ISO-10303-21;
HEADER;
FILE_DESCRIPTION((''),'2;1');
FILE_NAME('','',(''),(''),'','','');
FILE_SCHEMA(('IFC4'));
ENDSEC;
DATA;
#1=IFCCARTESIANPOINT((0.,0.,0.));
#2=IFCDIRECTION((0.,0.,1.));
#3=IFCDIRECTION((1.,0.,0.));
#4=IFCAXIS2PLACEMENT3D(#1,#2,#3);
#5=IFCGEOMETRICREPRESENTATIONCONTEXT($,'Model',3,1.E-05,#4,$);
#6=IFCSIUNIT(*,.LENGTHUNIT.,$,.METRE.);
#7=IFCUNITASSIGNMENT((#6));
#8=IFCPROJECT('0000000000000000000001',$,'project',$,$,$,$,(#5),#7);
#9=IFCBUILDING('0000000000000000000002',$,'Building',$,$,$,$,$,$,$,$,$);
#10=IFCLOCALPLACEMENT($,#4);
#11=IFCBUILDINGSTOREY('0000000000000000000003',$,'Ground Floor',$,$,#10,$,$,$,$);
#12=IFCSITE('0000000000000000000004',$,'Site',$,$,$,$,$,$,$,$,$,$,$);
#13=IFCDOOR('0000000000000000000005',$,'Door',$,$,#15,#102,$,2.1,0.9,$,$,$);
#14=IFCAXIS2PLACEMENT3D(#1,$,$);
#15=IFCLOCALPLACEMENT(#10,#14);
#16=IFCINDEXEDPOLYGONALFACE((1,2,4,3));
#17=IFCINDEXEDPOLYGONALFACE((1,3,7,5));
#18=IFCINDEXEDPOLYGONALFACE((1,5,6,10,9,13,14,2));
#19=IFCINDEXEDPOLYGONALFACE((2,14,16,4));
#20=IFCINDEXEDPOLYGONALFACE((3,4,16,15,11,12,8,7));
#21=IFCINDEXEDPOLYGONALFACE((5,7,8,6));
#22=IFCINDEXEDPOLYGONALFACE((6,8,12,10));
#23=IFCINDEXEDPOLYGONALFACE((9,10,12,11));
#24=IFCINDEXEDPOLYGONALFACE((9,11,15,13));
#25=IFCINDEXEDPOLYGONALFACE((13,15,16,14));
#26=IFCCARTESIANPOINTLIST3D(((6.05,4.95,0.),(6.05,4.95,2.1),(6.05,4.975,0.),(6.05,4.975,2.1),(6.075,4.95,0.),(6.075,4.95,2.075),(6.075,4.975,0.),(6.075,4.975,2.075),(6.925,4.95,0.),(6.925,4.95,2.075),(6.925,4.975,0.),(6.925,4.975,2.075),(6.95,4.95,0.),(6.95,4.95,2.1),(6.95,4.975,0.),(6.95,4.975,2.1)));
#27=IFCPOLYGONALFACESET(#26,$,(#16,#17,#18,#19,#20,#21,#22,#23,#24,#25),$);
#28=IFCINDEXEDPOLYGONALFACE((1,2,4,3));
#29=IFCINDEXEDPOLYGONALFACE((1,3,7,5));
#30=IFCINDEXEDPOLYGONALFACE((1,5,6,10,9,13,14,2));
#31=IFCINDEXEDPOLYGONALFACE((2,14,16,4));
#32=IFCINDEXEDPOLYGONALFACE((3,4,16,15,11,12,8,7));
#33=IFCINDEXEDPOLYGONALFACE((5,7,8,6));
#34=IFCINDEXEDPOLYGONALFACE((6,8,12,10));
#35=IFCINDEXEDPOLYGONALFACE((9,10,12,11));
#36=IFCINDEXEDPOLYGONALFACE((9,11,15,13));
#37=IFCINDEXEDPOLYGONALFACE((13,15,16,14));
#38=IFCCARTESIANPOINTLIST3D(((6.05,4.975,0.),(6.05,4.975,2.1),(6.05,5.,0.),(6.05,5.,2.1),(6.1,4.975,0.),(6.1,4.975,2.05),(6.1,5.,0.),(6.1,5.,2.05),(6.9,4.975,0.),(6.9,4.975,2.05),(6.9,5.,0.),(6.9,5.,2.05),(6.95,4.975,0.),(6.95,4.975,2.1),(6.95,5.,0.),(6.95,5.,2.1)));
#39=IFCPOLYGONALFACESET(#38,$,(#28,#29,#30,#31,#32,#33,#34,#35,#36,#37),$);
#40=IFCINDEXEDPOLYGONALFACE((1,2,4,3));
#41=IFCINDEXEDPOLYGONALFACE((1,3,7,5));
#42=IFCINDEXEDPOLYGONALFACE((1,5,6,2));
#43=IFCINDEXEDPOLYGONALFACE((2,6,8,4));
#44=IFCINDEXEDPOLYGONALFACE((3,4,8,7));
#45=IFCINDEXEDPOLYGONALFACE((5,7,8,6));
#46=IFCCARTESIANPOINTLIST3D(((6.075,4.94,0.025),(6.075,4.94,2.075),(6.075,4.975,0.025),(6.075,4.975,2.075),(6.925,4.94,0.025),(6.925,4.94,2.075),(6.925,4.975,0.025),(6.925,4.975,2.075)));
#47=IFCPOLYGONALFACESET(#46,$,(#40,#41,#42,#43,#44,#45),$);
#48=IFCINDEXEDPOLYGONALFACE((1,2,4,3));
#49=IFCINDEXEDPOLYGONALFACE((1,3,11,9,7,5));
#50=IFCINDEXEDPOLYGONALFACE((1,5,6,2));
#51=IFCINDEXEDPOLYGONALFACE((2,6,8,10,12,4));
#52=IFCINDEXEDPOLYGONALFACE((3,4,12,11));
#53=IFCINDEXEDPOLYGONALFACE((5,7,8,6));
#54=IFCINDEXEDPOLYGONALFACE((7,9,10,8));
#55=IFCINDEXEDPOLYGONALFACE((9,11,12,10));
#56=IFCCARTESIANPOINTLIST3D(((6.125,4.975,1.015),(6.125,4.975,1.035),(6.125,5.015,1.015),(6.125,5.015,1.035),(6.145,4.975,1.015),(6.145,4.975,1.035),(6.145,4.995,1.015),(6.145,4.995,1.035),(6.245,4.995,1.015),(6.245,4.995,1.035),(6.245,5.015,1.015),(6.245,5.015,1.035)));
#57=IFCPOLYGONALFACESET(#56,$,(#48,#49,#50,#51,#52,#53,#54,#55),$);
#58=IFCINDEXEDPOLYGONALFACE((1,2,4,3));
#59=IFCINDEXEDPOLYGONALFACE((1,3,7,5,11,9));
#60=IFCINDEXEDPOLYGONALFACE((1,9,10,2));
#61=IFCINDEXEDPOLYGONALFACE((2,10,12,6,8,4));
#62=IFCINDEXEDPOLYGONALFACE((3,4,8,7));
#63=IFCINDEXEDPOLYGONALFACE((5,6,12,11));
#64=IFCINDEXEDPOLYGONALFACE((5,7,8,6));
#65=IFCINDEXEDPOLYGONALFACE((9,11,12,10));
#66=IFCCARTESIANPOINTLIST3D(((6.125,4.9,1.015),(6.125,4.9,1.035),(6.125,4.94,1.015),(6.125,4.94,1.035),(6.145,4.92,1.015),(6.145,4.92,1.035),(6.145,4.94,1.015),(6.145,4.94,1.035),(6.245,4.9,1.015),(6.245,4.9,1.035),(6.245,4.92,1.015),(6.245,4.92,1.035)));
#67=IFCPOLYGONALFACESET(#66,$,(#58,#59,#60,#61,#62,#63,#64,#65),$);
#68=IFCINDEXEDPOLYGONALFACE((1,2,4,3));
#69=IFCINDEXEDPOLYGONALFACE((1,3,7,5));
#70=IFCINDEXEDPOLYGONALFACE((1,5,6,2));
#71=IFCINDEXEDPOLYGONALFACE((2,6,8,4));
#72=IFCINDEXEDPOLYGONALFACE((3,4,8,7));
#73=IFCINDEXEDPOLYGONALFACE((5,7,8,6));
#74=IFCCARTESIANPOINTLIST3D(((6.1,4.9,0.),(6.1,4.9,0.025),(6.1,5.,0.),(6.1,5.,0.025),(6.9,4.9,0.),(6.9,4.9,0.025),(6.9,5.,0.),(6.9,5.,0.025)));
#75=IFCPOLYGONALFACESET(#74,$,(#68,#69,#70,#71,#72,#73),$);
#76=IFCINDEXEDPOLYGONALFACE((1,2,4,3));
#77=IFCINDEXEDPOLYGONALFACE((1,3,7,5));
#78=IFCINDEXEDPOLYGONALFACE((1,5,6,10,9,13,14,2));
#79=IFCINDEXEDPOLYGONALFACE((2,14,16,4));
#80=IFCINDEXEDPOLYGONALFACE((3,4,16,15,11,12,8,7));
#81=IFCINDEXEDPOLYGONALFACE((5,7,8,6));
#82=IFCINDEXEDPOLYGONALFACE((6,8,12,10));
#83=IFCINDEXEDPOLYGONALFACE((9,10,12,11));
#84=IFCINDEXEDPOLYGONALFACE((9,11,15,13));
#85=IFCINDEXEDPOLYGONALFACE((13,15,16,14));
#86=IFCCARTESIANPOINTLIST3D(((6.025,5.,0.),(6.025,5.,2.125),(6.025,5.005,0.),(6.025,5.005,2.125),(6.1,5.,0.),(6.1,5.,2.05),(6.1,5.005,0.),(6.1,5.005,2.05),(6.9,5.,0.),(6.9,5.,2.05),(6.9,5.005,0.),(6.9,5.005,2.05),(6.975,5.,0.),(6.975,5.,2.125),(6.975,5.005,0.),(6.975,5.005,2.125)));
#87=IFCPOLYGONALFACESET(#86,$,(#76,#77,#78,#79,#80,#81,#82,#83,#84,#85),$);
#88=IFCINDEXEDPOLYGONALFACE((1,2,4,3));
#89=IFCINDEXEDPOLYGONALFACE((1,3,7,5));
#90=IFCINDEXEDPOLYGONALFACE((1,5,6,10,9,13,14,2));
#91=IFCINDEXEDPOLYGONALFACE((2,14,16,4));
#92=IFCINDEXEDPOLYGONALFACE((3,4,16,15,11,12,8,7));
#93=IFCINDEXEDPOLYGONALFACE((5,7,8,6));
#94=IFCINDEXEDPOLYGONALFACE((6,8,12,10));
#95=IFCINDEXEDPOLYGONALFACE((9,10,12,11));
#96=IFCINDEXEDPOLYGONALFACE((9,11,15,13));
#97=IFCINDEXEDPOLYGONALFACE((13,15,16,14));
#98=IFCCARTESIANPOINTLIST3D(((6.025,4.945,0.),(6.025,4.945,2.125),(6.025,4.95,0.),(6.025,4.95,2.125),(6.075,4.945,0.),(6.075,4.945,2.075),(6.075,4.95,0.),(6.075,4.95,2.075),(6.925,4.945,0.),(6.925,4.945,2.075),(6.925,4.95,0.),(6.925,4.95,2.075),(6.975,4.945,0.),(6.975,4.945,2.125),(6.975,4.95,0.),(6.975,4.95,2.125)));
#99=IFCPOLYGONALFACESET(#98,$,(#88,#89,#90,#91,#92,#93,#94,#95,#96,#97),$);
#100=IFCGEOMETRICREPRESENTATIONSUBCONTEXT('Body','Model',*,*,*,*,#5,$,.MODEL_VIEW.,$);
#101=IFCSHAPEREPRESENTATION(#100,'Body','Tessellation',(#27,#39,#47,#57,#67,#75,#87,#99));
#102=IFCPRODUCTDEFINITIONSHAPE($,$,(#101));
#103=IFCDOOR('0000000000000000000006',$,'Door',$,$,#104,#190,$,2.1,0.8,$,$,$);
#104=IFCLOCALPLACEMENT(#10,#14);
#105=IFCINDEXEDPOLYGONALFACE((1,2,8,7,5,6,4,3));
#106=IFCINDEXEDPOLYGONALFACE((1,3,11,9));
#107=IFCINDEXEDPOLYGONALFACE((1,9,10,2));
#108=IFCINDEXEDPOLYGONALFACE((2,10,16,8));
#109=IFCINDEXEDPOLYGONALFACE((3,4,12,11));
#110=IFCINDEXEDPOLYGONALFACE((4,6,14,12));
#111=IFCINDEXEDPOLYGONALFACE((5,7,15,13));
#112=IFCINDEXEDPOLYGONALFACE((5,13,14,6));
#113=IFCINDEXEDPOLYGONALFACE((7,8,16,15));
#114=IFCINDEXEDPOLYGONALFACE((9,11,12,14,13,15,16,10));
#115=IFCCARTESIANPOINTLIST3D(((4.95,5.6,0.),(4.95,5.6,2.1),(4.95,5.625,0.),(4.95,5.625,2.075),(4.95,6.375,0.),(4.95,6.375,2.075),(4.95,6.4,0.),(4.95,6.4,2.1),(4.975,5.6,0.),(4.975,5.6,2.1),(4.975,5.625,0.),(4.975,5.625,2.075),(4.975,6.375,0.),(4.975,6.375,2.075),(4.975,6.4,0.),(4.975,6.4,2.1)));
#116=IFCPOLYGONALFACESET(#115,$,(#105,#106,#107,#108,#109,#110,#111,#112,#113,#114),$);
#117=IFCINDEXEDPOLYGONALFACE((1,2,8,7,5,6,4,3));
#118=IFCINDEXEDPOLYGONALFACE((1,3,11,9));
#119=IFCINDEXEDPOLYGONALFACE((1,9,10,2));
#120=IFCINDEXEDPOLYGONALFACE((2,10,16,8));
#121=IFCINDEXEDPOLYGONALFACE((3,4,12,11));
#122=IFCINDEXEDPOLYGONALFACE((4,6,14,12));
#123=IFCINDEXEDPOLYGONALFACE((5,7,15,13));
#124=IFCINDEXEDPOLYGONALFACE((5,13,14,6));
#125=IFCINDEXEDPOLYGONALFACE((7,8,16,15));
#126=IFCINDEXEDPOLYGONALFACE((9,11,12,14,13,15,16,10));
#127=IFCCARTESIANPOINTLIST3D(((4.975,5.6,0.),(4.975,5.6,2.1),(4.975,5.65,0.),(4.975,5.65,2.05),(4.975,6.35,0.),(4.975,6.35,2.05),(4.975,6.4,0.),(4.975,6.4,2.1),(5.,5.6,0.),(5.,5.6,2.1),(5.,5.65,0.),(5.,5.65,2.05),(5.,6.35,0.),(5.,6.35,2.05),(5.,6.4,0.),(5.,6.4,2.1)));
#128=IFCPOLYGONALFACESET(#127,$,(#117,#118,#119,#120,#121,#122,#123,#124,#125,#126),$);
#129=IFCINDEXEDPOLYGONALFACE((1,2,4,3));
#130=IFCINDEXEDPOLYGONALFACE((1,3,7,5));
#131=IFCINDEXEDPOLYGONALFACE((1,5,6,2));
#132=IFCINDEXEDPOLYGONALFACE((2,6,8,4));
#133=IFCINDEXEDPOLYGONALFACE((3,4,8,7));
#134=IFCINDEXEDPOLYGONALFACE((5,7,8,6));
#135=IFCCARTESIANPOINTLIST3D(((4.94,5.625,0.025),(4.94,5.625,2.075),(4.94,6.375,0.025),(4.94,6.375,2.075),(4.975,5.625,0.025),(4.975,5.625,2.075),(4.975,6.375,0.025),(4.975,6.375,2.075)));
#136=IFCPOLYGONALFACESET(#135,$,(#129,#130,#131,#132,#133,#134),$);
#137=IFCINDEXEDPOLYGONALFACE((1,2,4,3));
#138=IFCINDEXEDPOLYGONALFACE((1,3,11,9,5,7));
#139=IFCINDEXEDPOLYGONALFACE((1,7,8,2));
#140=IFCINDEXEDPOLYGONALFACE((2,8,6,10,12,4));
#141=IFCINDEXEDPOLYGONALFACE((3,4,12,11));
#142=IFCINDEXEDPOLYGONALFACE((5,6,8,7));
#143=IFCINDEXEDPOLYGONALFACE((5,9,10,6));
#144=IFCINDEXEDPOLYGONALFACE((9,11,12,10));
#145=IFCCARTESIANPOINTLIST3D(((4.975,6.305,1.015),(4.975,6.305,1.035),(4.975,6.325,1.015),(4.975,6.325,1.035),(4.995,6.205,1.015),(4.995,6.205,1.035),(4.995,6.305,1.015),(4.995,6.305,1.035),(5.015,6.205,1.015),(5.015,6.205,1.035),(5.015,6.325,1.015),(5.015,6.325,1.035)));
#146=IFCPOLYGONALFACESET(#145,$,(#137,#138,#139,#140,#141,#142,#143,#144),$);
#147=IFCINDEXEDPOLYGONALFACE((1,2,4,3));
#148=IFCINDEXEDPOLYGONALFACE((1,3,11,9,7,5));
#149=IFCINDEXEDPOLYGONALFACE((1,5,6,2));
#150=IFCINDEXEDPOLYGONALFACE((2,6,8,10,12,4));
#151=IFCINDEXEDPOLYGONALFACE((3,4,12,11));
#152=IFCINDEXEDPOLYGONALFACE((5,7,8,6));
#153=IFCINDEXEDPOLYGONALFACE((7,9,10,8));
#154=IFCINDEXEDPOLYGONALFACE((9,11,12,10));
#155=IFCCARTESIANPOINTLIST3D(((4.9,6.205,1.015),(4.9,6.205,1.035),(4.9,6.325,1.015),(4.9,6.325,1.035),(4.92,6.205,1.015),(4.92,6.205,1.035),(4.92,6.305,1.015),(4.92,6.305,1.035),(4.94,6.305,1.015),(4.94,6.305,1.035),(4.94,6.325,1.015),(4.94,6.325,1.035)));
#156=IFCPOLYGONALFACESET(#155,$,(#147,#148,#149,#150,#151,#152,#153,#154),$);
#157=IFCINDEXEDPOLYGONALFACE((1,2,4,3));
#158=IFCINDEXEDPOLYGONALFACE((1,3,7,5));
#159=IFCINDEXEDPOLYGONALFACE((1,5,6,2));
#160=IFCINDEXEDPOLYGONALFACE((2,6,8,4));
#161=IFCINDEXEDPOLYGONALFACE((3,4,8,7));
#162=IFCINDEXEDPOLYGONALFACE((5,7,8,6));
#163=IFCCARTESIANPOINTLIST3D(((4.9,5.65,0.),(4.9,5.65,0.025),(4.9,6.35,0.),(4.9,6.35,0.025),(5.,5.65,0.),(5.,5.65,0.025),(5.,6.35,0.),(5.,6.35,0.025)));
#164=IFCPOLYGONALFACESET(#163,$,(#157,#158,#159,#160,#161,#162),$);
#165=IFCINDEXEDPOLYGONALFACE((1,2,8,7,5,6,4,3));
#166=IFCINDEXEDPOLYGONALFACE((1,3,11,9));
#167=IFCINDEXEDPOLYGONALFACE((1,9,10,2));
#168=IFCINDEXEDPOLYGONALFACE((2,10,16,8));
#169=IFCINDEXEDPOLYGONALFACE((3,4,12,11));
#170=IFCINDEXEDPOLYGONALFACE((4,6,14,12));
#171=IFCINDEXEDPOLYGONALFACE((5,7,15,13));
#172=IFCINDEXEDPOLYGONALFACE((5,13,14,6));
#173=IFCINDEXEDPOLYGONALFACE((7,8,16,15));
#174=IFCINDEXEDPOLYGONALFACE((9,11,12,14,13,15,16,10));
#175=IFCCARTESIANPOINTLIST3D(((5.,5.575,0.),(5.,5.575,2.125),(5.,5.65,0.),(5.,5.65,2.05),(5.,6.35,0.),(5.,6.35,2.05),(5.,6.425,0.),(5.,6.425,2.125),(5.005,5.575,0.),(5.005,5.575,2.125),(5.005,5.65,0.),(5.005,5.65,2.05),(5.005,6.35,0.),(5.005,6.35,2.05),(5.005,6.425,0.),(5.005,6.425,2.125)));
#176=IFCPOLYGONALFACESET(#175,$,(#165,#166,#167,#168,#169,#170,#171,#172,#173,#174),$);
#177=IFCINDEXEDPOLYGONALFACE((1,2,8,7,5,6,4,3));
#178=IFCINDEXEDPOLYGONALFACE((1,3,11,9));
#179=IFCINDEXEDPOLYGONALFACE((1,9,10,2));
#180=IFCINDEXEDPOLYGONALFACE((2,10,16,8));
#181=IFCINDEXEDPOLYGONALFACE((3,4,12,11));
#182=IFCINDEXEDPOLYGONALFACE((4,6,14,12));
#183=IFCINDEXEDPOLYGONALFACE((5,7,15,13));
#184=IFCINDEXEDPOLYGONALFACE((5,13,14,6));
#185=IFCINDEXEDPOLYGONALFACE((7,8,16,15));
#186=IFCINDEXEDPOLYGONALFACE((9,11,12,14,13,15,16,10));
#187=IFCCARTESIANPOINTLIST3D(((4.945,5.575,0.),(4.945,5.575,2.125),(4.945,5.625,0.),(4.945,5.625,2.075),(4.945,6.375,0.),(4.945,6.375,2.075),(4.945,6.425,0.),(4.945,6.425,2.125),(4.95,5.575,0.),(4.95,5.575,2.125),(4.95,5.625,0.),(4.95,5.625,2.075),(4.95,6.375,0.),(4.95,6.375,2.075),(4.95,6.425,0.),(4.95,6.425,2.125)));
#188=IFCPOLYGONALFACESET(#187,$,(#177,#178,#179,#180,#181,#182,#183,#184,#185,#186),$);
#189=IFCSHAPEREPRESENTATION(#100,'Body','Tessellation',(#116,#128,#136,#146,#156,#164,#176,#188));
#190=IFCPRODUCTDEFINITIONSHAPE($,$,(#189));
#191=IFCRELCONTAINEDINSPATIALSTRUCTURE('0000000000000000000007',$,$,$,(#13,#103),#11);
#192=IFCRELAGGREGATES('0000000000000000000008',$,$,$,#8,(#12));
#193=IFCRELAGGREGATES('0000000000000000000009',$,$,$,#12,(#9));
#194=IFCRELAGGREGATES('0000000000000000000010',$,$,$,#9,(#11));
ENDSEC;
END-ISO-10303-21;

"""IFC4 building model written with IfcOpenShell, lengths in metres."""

from ifc_helpers import new_model, si_unit, frame, origin_with_axes, place, context, subcontext, project, spatial, line, indexed_curve, outline, extrude, element, save


model = new_model("IFC4")

# Units and contexts
model_context = context("Model", 3, precision=1e-05, world=origin_with_axes())
body_context = subcontext(model_context, "Body", "Model", "MODEL_VIEW")
ifc_project = project(units=[si_unit("LENGTHUNIT", "METRE")], contexts=[model_context])

# Site, building, storey
site = spatial("IfcSite", under=ifc_project, Name="Site")
building = spatial("IfcBuilding", under=site, Name="Building")
storey_placement = place(None, origin_with_axes())
storey = spatial("IfcBuildingStorey", under=building, at=storey_placement, Name="Ground Floor")

# Doors
door_1_placement = place(storey_placement, frame((6.95, 5.0, 0.0), z_axis=(0.0, 0.0, 1.0), x_axis=(-1.0, 0.0, 0.0)))
element("IfcDoor", 1, at=door_1_placement, inside=storey, Name="Door", OverallHeight=2.1, OverallWidth=0.9, context=body_context, shape_type="SweptSolid", body=[
    extrude(outline(indexed_curve([(0.0, 0.0), (0.0, 2.1), (0.9, 2.1), (0.9, 0.0), (0.875, 0.0), (0.875, 2.075), (0.025, 2.075), (0.025, 0.0)], segments=[line(1, 2, 3, 4, 5, 6, 7, 8, 1)])), frame((0.0, 0.025, 0.0), z_axis=(0.0, -1.0, 0.0), x_axis=(1.0, 0.0, 0.0)), (0.0, 0.0, -1.0), 0.025),
    extrude(outline(indexed_curve([(0.0, 0.0), (0.0, 2.1), (0.9, 2.1), (0.9, 0.0), (0.85, 0.0), (0.85, 2.05), (0.05, 2.05), (0.05, 0.0)], segments=[line(1, 2, 3, 4, 5, 6, 7, 8, 1)])), frame((0.0, 0.0, 0.0), z_axis=(0.0, -1.0, 0.0), x_axis=(1.0, 0.0, 0.0)), (0.0, 0.0, -1.0), 0.025),
    extrude(outline(indexed_curve([(0.0, 0.0), (0.85, 0.0), (0.85, 0.035), (0.0, 0.035)], segments=[line(1, 2, 3, 4, 1)])), frame((0.025, 0.025, 0.025), z_axis=(0.0, 0.0, 1.0), x_axis=(1.0, 0.0, 0.0)), (0.0, 0.0, 1.0), 2.05),
    extrude(outline(indexed_curve([(0.0, 0.0), (0.0, -0.04), (-0.12, -0.04), (-0.12, -0.02), (-0.02, -0.02), (-0.02, 0.0)], segments=[line(1, 2, 3, 4, 5, 6, 1)])), frame((0.825, 0.025, 1.015), z_axis=(0.0, 0.0, 1.0), x_axis=(1.0, 0.0, 0.0)), (0.0, 0.0, 1.0), 0.02),
    extrude(outline(indexed_curve([(0.0, 0.0), (0.0, 0.04), (-0.12, 0.04), (-0.12, 0.02), (-0.02, 0.02), (-0.02, 0.0)], segments=[line(1, 2, 3, 4, 5, 6, 1)])), frame((0.825, 0.06, 1.015), z_axis=(0.0, 0.0, 1.0), x_axis=(1.0, 0.0, 0.0)), (0.0, 0.0, 1.0), 0.02),
    extrude(outline(indexed_curve([(0.0, 0.0), (0.8, 0.0), (0.8, 0.1), (0.0, 0.1)], segments=[line(1, 2, 3, 4, 1)])), frame((0.05, 0.0, 0.0), z_axis=(0.0, 0.0, 1.0), x_axis=(1.0, 0.0, 0.0)), (0.0, 0.0, 1.0), 0.025),
    extrude(outline(indexed_curve([(0.0, 0.0), (0.0, 2.125), (0.95, 2.125), (0.95, 0.0), (0.875, 0.0), (0.875, 2.05), (0.075, 2.05), (0.075, 0.0)], segments=[line(1, 2, 3, 4, 5, 6, 7, 8, 1)])), frame((-0.025, -0.005, 0.0), z_axis=(0.0, -1.0, 0.0), x_axis=(1.0, 0.0, 0.0)), (0.0, 0.0, -1.0), 0.005),
    extrude(outline(indexed_curve([(0.0, 0.0), (0.0, 2.125), (0.95, 2.125), (0.95, 0.0), (0.9, 0.0), (0.9, 2.075), (0.05, 2.075), (0.05, 0.0)], segments=[line(1, 2, 3, 4, 5, 6, 7, 8, 1)])), frame((-0.025, 0.05, 0.0), z_axis=(0.0, -1.0, 0.0), x_axis=(1.0, 0.0, 0.0)), (0.0, 0.0, -1.0), 0.005),
])
door_2_placement = place(storey_placement, frame((5.0, 5.6, 0.0), z_axis=(0.0, 0.0, 1.0), x_axis=(0.0, 1.0, 0.0)))
element("IfcDoor", 2, at=door_2_placement, inside=storey, Name="Door", OverallHeight=2.1, OverallWidth=0.8, context=body_context, shape_type="SweptSolid", body=[
    extrude(outline(indexed_curve([(0.0, 0.0), (0.0, 2.1), (0.8, 2.1), (0.8, 0.0), (0.775, 0.0), (0.775, 2.075), (0.025, 2.075), (0.025, 0.0)], segments=[line(1, 2, 3, 4, 5, 6, 7, 8, 1)])), frame((0.0, 0.025, 0.0), z_axis=(0.0, -1.0, 0.0), x_axis=(1.0, 0.0, 0.0)), (0.0, 0.0, -1.0), 0.025),
    extrude(outline(indexed_curve([(0.0, 0.0), (0.0, 2.1), (0.8, 2.1), (0.8, 0.0), (0.75, 0.0), (0.75, 2.05), (0.05, 2.05), (0.05, 0.0)], segments=[line(1, 2, 3, 4, 5, 6, 7, 8, 1)])), frame((0.0, 0.0, 0.0), z_axis=(0.0, -1.0, 0.0), x_axis=(1.0, 0.0, 0.0)), (0.0, 0.0, -1.0), 0.025),
    extrude(outline(indexed_curve([(0.0, 0.0), (0.75, 0.0), (0.75, 0.035), (0.0, 0.035)], segments=[line(1, 2, 3, 4, 1)])), frame((0.025, 0.025, 0.025), z_axis=(0.0, 0.0, 1.0), x_axis=(1.0, 0.0, 0.0)), (0.0, 0.0, 1.0), 2.05),
    extrude(outline(indexed_curve([(0.0, 0.0), (0.0, -0.04), (-0.12, -0.04), (-0.12, -0.02), (-0.02, -0.02), (-0.02, 0.0)], segments=[line(1, 2, 3, 4, 5, 6, 1)])), frame((0.725, 0.025, 1.015), z_axis=(0.0, 0.0, 1.0), x_axis=(1.0, 0.0, 0.0)), (0.0, 0.0, 1.0), 0.02),
    extrude(outline(indexed_curve([(0.0, 0.0), (0.0, 0.04), (-0.12, 0.04), (-0.12, 0.02), (-0.02, 0.02), (-0.02, 0.0)], segments=[line(1, 2, 3, 4, 5, 6, 1)])), frame((0.725, 0.06, 1.015), z_axis=(0.0, 0.0, 1.0), x_axis=(1.0, 0.0, 0.0)), (0.0, 0.0, 1.0), 0.02),
    extrude(outline(indexed_curve([(0.0, 0.0), (0.7, 0.0), (0.7, 0.1), (0.0, 0.1)], segments=[line(1, 2, 3, 4, 1)])), frame((0.05, 0.0, 0.0), z_axis=(0.0, 0.0, 1.0), x_axis=(1.0, 0.0, 0.0)), (0.0, 0.0, 1.0), 0.025),
    extrude(outline(indexed_curve([(0.0, 0.0), (0.0, 2.125), (0.85, 2.125), (0.85, 0.0), (0.775, 0.0), (0.775, 2.05), (0.075, 2.05), (0.075, 0.0)], segments=[line(1, 2, 3, 4, 5, 6, 7, 8, 1)])), frame((-0.025, -0.005, 0.0), z_axis=(0.0, -1.0, 0.0), x_axis=(1.0, 0.0, 0.0)), (0.0, 0.0, -1.0), 0.005),
    extrude(outline(indexed_curve([(0.0, 0.0), (0.0, 2.125), (0.85, 2.125), (0.85, 0.0), (0.8, 0.0), (0.8, 2.075), (0.05, 2.075), (0.05, 0.0)], segments=[line(1, 2, 3, 4, 5, 6, 7, 8, 1)])), frame((-0.025, 0.05, 0.0), z_axis=(0.0, -1.0, 0.0), x_axis=(1.0, 0.0, 0.0)), (0.0, 0.0, -1.0), 0.005),
])

save(model, "model.ifc")
